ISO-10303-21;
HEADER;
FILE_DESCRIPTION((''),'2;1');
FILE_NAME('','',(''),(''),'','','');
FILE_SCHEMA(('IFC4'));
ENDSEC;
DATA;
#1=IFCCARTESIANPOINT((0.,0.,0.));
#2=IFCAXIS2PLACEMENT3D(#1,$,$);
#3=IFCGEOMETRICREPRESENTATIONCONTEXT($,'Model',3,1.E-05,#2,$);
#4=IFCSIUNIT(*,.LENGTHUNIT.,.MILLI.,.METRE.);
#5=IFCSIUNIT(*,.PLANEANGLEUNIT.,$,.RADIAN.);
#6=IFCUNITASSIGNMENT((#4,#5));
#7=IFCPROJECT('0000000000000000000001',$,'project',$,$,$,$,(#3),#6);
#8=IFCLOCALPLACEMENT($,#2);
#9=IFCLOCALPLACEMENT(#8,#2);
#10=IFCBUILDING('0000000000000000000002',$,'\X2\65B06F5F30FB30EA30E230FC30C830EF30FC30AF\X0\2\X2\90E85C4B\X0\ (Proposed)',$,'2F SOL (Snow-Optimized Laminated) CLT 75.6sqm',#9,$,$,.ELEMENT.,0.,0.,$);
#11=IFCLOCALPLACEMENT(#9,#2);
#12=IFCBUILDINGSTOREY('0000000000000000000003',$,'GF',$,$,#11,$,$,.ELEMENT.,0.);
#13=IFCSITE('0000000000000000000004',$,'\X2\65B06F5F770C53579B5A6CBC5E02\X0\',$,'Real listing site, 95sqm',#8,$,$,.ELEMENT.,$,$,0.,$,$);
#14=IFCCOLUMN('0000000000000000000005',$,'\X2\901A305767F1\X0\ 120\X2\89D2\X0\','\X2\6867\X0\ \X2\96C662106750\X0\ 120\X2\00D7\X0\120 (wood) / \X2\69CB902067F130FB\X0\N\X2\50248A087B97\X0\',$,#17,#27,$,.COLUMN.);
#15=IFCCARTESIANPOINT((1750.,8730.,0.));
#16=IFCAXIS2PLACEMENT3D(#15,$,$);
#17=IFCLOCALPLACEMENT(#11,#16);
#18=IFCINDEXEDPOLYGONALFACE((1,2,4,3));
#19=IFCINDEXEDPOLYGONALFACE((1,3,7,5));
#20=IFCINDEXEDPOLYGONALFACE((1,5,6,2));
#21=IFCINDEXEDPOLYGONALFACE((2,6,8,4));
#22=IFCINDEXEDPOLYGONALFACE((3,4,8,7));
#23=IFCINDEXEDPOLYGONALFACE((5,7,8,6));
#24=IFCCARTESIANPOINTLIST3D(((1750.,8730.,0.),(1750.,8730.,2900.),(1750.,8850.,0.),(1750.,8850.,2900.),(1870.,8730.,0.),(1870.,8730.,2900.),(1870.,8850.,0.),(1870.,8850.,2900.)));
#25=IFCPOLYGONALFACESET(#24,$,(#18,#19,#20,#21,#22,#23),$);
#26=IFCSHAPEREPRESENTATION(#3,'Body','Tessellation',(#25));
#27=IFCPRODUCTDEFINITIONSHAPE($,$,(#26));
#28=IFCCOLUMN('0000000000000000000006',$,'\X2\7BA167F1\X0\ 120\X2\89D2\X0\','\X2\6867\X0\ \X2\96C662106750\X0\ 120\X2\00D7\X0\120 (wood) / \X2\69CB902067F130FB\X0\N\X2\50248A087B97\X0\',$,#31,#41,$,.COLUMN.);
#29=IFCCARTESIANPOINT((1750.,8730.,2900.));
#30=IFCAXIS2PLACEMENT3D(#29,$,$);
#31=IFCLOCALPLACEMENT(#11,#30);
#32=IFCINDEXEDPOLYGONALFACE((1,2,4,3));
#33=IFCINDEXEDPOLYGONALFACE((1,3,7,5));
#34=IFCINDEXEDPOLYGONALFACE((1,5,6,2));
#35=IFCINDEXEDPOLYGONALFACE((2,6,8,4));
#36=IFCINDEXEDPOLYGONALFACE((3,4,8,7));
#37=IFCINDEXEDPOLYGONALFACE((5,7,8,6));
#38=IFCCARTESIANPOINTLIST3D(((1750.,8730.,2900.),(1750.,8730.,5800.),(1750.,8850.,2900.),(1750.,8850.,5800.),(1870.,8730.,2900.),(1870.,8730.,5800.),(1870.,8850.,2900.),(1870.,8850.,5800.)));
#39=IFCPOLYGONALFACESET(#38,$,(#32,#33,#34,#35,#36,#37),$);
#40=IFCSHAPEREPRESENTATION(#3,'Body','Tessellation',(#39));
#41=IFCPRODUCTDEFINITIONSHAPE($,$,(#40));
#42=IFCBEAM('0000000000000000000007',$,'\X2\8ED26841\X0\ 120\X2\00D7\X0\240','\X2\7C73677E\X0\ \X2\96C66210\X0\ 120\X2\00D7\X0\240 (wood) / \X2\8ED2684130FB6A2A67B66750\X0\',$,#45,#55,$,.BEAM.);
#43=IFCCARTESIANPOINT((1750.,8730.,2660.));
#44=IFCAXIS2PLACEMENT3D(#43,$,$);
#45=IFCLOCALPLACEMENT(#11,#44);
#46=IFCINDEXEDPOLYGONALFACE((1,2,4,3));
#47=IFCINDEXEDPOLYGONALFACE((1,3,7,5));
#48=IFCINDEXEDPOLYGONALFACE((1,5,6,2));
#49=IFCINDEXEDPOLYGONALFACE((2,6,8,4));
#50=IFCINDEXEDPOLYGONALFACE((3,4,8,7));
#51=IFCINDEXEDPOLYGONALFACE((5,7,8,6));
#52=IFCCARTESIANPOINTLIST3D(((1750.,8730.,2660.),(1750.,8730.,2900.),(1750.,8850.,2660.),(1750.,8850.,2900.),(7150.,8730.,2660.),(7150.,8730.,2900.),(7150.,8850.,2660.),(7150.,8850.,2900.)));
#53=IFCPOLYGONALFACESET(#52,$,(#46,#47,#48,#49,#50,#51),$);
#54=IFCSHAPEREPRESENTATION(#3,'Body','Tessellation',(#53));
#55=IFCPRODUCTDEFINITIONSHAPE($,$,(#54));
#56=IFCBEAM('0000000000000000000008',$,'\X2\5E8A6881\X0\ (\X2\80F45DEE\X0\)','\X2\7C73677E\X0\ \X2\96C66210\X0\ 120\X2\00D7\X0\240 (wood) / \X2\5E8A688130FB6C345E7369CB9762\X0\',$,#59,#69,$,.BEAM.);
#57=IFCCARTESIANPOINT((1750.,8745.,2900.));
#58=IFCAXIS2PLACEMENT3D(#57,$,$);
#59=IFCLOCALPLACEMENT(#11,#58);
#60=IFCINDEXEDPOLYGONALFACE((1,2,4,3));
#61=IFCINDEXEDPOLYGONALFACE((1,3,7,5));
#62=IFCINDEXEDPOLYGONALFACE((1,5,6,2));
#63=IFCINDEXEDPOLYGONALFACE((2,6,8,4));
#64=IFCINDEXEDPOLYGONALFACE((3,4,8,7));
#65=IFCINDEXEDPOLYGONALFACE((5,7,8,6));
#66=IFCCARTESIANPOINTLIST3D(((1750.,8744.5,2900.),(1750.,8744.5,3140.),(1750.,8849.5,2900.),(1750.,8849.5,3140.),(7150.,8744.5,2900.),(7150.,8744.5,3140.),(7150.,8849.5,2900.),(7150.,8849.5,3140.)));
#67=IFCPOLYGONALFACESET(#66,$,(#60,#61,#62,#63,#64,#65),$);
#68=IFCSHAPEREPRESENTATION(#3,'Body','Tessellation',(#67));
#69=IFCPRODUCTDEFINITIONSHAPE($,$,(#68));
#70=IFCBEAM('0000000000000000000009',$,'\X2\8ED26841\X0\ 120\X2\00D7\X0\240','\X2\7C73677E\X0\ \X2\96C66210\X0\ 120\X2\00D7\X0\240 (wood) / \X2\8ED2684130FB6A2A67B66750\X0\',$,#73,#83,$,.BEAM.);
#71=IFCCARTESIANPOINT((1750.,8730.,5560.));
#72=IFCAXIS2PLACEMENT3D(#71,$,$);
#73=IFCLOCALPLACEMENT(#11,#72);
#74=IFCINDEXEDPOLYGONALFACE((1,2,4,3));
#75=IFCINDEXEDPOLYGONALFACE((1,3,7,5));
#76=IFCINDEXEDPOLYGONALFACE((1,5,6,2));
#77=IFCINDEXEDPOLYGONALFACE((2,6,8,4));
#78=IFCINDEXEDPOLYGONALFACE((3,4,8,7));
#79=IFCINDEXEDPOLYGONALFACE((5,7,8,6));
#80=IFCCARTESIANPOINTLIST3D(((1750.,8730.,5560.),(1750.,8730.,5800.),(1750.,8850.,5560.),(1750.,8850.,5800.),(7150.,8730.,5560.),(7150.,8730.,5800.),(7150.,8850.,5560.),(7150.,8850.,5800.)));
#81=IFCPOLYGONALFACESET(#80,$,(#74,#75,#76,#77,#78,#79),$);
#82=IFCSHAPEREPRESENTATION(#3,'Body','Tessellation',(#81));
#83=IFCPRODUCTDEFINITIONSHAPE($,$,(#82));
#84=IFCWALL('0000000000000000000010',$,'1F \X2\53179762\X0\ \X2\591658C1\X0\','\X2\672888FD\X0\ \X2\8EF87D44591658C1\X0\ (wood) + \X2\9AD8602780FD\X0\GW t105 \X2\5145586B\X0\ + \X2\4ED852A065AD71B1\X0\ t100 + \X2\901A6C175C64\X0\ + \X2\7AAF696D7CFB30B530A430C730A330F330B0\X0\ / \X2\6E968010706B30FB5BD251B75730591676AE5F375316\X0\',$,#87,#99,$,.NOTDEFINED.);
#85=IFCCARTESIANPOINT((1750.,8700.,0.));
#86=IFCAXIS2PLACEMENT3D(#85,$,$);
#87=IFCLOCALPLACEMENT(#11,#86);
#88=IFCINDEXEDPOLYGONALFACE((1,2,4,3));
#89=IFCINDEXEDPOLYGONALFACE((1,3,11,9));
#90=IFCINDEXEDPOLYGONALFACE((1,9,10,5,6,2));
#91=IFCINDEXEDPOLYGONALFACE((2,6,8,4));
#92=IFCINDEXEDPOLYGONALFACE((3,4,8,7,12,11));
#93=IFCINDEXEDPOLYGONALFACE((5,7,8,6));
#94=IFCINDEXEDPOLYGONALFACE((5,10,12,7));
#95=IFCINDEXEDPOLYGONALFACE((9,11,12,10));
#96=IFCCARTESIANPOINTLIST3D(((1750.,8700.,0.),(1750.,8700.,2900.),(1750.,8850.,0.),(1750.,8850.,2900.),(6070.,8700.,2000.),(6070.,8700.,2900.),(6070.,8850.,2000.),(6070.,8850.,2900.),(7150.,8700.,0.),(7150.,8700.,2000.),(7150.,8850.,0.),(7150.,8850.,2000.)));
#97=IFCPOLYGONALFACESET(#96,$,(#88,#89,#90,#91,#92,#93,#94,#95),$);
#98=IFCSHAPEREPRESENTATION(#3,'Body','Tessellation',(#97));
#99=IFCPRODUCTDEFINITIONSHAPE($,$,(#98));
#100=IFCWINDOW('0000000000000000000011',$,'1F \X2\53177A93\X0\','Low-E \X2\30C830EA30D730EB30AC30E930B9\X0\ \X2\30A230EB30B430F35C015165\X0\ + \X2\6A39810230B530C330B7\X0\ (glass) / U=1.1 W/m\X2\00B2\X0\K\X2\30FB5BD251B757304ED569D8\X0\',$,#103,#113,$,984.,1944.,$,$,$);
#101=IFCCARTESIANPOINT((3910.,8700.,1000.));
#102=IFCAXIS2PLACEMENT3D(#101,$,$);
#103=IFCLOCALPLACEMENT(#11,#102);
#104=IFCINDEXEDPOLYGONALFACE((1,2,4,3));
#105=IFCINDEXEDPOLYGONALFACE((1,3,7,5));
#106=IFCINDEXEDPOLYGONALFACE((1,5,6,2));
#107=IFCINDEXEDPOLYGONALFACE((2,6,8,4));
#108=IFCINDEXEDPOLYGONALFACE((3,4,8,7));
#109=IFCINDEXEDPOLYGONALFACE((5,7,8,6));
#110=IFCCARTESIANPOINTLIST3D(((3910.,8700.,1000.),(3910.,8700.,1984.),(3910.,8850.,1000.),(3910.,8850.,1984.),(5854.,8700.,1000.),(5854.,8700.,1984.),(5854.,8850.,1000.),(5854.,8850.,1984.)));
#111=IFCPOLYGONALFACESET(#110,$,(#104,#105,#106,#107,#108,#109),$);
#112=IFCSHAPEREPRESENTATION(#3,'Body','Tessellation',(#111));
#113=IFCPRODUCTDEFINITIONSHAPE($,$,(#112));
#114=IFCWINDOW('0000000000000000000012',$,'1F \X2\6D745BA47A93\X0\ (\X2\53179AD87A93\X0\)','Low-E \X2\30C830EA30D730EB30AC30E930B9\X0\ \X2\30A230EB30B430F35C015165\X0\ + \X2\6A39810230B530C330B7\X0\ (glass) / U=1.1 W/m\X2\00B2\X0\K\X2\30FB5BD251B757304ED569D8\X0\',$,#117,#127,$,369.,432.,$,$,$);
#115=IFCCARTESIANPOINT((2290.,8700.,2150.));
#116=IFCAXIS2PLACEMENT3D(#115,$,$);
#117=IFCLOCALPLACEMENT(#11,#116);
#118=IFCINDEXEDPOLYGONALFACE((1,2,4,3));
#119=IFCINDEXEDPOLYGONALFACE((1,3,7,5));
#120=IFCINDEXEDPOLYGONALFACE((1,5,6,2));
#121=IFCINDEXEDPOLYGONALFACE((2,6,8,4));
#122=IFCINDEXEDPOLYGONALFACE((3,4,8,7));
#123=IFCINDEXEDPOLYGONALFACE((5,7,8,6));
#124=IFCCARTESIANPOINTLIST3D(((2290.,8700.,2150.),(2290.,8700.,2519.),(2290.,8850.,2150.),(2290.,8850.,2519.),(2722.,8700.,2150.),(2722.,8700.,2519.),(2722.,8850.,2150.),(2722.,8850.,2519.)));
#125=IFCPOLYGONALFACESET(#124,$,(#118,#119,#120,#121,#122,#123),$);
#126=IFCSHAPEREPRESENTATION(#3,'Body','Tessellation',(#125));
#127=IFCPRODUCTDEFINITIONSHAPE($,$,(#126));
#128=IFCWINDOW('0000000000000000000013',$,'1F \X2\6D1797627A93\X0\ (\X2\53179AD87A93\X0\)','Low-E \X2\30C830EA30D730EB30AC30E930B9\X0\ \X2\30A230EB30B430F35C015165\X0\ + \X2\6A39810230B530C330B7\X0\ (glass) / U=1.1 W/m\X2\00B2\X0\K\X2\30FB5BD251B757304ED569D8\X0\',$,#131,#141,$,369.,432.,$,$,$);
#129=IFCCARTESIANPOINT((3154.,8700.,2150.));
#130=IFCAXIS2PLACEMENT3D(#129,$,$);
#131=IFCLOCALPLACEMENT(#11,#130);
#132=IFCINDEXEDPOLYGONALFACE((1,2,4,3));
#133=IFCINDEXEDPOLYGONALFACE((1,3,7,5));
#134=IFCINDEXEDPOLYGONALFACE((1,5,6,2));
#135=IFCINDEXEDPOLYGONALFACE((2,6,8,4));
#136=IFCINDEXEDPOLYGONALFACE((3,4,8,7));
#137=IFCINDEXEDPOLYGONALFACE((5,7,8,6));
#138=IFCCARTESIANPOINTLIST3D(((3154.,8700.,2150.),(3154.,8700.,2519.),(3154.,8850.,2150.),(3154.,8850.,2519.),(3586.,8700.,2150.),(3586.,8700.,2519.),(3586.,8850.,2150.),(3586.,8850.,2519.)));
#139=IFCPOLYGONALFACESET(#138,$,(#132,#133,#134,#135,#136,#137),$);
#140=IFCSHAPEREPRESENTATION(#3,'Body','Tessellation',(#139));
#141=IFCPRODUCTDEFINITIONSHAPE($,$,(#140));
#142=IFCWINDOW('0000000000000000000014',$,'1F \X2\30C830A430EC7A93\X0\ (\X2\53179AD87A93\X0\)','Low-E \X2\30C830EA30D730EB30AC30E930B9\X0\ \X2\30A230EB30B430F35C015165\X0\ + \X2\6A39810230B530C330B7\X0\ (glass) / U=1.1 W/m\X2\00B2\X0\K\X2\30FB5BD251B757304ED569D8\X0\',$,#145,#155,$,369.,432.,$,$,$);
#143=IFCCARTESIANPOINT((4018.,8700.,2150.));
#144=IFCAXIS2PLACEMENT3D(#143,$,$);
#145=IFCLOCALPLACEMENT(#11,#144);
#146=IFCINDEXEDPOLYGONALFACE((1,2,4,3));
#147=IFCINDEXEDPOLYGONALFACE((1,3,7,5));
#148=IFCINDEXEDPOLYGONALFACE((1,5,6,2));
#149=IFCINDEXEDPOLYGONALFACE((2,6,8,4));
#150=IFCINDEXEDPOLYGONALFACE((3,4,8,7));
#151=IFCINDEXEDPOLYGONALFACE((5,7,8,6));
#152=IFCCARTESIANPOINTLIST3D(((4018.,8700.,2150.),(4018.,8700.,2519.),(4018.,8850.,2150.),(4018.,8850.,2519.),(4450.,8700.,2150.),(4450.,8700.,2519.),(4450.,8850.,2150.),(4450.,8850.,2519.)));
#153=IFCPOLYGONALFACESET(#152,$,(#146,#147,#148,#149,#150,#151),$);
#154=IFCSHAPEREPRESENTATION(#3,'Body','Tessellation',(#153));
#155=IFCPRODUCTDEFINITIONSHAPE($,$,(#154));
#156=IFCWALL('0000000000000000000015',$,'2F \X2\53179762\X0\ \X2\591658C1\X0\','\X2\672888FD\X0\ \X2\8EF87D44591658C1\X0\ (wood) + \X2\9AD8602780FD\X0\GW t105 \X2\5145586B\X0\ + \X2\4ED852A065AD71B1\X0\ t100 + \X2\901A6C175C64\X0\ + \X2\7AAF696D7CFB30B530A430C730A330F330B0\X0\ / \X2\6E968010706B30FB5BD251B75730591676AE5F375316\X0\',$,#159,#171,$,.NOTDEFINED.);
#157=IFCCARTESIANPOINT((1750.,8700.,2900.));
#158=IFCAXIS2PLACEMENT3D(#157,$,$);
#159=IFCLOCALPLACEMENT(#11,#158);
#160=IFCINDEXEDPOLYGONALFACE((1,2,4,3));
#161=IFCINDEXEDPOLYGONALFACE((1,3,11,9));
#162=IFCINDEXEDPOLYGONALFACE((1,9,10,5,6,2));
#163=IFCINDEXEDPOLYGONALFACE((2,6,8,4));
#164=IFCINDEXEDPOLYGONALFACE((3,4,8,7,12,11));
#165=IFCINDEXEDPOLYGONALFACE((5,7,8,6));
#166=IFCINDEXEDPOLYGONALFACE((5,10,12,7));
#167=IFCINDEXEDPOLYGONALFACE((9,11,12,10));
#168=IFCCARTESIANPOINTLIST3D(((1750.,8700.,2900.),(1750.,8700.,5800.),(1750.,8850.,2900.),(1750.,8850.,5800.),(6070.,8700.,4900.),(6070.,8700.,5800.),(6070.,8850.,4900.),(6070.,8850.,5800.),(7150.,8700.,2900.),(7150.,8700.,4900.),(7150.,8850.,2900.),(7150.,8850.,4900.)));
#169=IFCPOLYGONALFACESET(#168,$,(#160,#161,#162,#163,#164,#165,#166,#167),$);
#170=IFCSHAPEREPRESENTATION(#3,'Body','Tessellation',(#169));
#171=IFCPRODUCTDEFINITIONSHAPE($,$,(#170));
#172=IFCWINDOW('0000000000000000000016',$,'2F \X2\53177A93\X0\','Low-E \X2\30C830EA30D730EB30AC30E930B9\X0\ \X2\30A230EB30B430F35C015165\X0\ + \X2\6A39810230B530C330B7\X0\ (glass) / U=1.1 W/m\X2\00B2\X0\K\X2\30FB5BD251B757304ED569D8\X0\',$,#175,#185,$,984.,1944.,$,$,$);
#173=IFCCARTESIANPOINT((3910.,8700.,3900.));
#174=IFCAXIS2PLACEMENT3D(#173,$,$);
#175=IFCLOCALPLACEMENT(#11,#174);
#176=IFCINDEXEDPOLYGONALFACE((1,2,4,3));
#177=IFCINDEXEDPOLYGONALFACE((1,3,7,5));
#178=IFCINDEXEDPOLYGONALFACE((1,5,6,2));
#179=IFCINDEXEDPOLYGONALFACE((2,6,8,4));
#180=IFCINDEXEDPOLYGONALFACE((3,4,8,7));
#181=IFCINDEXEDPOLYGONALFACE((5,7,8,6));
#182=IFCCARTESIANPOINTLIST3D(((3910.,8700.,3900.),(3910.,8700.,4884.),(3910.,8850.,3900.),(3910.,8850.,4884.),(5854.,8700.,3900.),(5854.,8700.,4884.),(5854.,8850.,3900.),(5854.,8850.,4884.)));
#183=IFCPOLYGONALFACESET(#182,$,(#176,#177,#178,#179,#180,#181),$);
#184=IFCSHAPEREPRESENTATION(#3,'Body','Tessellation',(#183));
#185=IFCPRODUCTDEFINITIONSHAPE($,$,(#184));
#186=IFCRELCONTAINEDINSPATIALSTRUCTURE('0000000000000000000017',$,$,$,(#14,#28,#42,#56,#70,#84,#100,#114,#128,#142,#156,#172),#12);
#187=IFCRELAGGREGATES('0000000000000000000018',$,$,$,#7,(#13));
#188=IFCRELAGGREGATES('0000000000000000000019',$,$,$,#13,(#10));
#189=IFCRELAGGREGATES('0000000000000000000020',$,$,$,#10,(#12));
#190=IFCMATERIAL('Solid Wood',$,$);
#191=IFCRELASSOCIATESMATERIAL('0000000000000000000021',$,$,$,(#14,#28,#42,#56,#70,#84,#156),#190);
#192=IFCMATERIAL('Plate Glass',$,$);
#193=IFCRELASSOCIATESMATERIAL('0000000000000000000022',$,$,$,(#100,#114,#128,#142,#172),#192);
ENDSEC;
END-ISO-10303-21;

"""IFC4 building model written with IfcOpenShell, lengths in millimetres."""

from ifc_helpers import new_model, si_unit, frame, frame_2d, origin, place, context, project, spatial, rectangle, extrude, material, element, fill, save


model = new_model("IFC4")

# Units and contexts
model_context = context("Model", 3, precision=1e-05, world=origin())
ifc_project = project(units=[si_unit("LENGTHUNIT", "METRE", prefix="MILLI"), si_unit("PLANEANGLEUNIT", "RADIAN")], contexts=[model_context])

# Site, building, storey
site_placement = place(None, origin())
site = spatial("IfcSite", under=ifc_project, at=site_placement, Name="新潟県南魚沼市", ObjectType="Real listing site, 95sqm", CompositionType="ELEMENT", RefElevation=0.0)
building_placement = place(site_placement, origin())
building = spatial("IfcBuilding", under=site, at=building_placement, Name="新潟・リモートワーク2部屋 (Proposed)", ObjectType="2F SOL (Snow-Optimized Laminated) CLT 75.6sqm", CompositionType="ELEMENT", ElevationOfRefHeight=0.0, ElevationOfTerrain=0.0)
storey_placement = place(building_placement, origin())
storey = spatial("IfcBuildingStorey", under=building, at=storey_placement, Name="GF", CompositionType="ELEMENT", Elevation=0.0)

# Columns
ifc_material_1 = material(Name="Solid Wood")
column_1_placement = place(storey_placement, frame((1750.0, 8730.0, 0.0)))
element("IfcColumn", 1, at=column_1_placement, inside=storey, material=ifc_material_1, Name="通し柱 120角", Description="桧 集成材 120×120 (wood) / 構造柱・N値計算", PredefinedType="COLUMN", context=model_context, shape_type="SweptSolid", body=[
    extrude(rectangle(XDim=120.0, YDim=120.0, at=frame_2d((60.0, 60.0))), frame((1750.0, 8730.0, 0.0)), (0.0, 0.0, 1.0), 2900.0),
])
column_2_placement = place(storey_placement, frame((1750.0, 8730.0, 2900.0)))
element("IfcColumn", 2, at=column_2_placement, inside=storey, material=ifc_material_1, Name="管柱 120角", Description="桧 集成材 120×120 (wood) / 構造柱・N値計算", PredefinedType="COLUMN", context=model_context, shape_type="SweptSolid", body=[
    extrude(rectangle(XDim=120.0, YDim=120.0, at=frame_2d((60.0, 60.0))), frame((1750.0, 8730.0, 2900.0)), (0.0, 0.0, 1.0), 2900.0),
])

# Beams
beam_1_placement = place(storey_placement, frame((1750.0, 8730.0, 2660.0)))
element("IfcBeam", 3, at=beam_1_placement, inside=storey, material=ifc_material_1, Name="軒桁 120×240", Description="米松 集成 120×240 (wood) / 軒桁・横架材", PredefinedType="BEAM", context=model_context, shape_type="SweptSolid", body=[
    extrude(rectangle(XDim=5400.0, YDim=120.0, at=frame_2d((2700.0, 60.0))), frame((1750.0, 8730.0, 2660.0)), (0.0, 0.0, 1.0), 240.0),
])
beam_2_placement = place(storey_placement, frame((1750.0, 8745.0, 2900.0)))
element("IfcBeam", 4, at=beam_2_placement, inside=storey, material=ifc_material_1, Name="床梁 (胴差)", Description="米松 集成 120×240 (wood) / 床梁・水平構面", PredefinedType="BEAM", context=model_context, shape_type="SweptSolid", body=[
    extrude(rectangle(XDim=5400.0, YDim=105.0, at=frame_2d((2700.0, 52.0))), frame((1750.0, 8745.0, 2900.0)), (0.0, 0.0, 1.0), 240.0),
])
beam_3_placement = place(storey_placement, frame((1750.0, 8730.0, 5560.0)))
element("IfcBeam", 5, at=beam_3_placement, inside=storey, material=ifc_material_1, Name="軒桁 120×240", Description="米松 集成 120×240 (wood) / 軒桁・横架材", PredefinedType="BEAM", context=model_context, shape_type="SweptSolid", body=[
    extrude(rectangle(XDim=5400.0, YDim=120.0, at=frame_2d((2700.0, 60.0))), frame((1750.0, 8730.0, 5560.0)), (0.0, 0.0, 1.0), 240.0),
])

# Wall, openings, windows
wall_1_placement = place(storey_placement, frame((1750.0, 8700.0, 0.0)))
wall_1 = element("IfcWall", 6, at=wall_1_placement, inside=storey, material=ifc_material_1, Name="1F 北面 外壁", Description="木製 軸組外壁 (wood) + 高性能GW t105 充填 + 付加断熱 t100 + 通気層 + 窯業系サイディング / 準耐火・寒冷地外皮強化", PredefinedType="NOTDEFINED", context=model_context, shape_type="SweptSolid", body=[
    extrude(rectangle(XDim=5400.0, YDim=150.0, at=frame_2d((2700.0, 75.0))), frame((1750.0, 8700.0, 0.0)), (0.0, 0.0, 1.0), 2900.0),
])
opening_1_placement = place(storey_placement, frame((3910.0, 8700.0, 1000.0)))
opening_1 = element("IfcOpeningElement", 7, at=opening_1_placement, cuts=wall_1, PredefinedType="NOTDEFINED", context=model_context, shape_type="SweptSolid", body=[
    extrude(rectangle(XDim=1944.0, YDim=150.0, at=frame_2d((972.0, 75.0))), frame((3910.0, 8700.0, 1000.0)), (0.0, 0.0, 1.0), 984.0),
])
opening_2_placement = place(storey_placement, frame((2290.0, 8700.0, 2150.0)))
opening_2 = element("IfcOpeningElement", 8, at=opening_2_placement, cuts=wall_1, PredefinedType="NOTDEFINED", context=model_context, shape_type="SweptSolid", body=[
    extrude(rectangle(XDim=432.0, YDim=150.0, at=frame_2d((216.0, 75.0))), frame((2290.0, 8700.0, 2150.0)), (0.0, 0.0, 1.0), 369.0),
])
opening_3_placement = place(storey_placement, frame((3154.0, 8700.0, 2150.0)))
opening_3 = element("IfcOpeningElement", 9, at=opening_3_placement, cuts=wall_1, PredefinedType="NOTDEFINED", context=model_context, shape_type="SweptSolid", body=[
    extrude(rectangle(XDim=432.0, YDim=150.0, at=frame_2d((216.0, 75.0))), frame((3154.0, 8700.0, 2150.0)), (0.0, 0.0, 1.0), 369.0),
])
opening_4_placement = place(storey_placement, frame((4018.0, 8700.0, 2150.0)))
opening_4 = element("IfcOpeningElement", 10, at=opening_4_placement, cuts=wall_1, PredefinedType="NOTDEFINED", context=model_context, shape_type="SweptSolid", body=[
    extrude(rectangle(XDim=432.0, YDim=150.0, at=frame_2d((216.0, 75.0))), frame((4018.0, 8700.0, 2150.0)), (0.0, 0.0, 1.0), 369.0),
])
ifc_material_2 = material(Name="Plate Glass")
window_1_placement = place(storey_placement, frame((3910.0, 8700.0, 1000.0)))
window_1 = element("IfcWindow", 11, at=window_1_placement, inside=storey, material=ifc_material_2, Name="1F 北窓", Description="Low-E トリプルガラス アルゴン封入 + 樹脂サッシ (glass) / U=1.1 W/m²K・寒冷地仕様", OverallHeight=984.0, OverallWidth=1944.0, context=model_context, shape_type="SweptSolid", body=[
    extrude(rectangle(XDim=1944.0, YDim=150.0, at=frame_2d((972.0, 75.0))), frame((3910.0, 8700.0, 1000.0)), (0.0, 0.0, 1.0), 984.0),
])
fill(opening_1, window_1)
window_2_placement = place(storey_placement, frame((2290.0, 8700.0, 2150.0)))
window_2 = element("IfcWindow", 12, at=window_2_placement, inside=storey, material=ifc_material_2, Name="1F 浴室窓 (北高窓)", Description="Low-E トリプルガラス アルゴン封入 + 樹脂サッシ (glass) / U=1.1 W/m²K・寒冷地仕様", OverallHeight=369.0, OverallWidth=432.0, context=model_context, shape_type="SweptSolid", body=[
    extrude(rectangle(XDim=432.0, YDim=150.0, at=frame_2d((216.0, 75.0))), frame((2290.0, 8700.0, 2150.0)), (0.0, 0.0, 1.0), 369.0),
])
fill(opening_2, window_2)
window_3_placement = place(storey_placement, frame((3154.0, 8700.0, 2150.0)))
window_3 = element("IfcWindow", 13, at=window_3_placement, inside=storey, material=ifc_material_2, Name="1F 洗面窓 (北高窓)", Description="Low-E トリプルガラス アルゴン封入 + 樹脂サッシ (glass) / U=1.1 W/m²K・寒冷地仕様", OverallHeight=369.0, OverallWidth=432.0, context=model_context, shape_type="SweptSolid", body=[
    extrude(rectangle(XDim=432.0, YDim=150.0, at=frame_2d((216.0, 75.0))), frame((3154.0, 8700.0, 2150.0)), (0.0, 0.0, 1.0), 369.0),
])
fill(opening_3, window_3)
window_4_placement = place(storey_placement, frame((4018.0, 8700.0, 2150.0)))
window_4 = element("IfcWindow", 14, at=window_4_placement, inside=storey, material=ifc_material_2, Name="1F トイレ窓 (北高窓)", Description="Low-E トリプルガラス アルゴン封入 + 樹脂サッシ (glass) / U=1.1 W/m²K・寒冷地仕様", OverallHeight=369.0, OverallWidth=432.0, context=model_context, shape_type="SweptSolid", body=[
    extrude(rectangle(XDim=432.0, YDim=150.0, at=frame_2d((216.0, 75.0))), frame((4018.0, 8700.0, 2150.0)), (0.0, 0.0, 1.0), 369.0),
])
fill(opening_4, window_4)

# Wall, opening, window
wall_2_placement = place(storey_placement, frame((1750.0, 8700.0, 2900.0)))
wall_2 = element("IfcWall", 15, at=wall_2_placement, inside=storey, material=ifc_material_1, Name="2F 北面 外壁", Description="木製 軸組外壁 (wood) + 高性能GW t105 充填 + 付加断熱 t100 + 通気層 + 窯業系サイディング / 準耐火・寒冷地外皮強化", PredefinedType="NOTDEFINED", context=model_context, shape_type="SweptSolid", body=[
    extrude(rectangle(XDim=5400.0, YDim=150.0, at=frame_2d((2700.0, 75.0))), frame((1750.0, 8700.0, 2900.0)), (0.0, 0.0, 1.0), 2900.0),
])
opening_5_placement = place(storey_placement, frame((3910.0, 8700.0, 3900.0)))
opening_5 = element("IfcOpeningElement", 16, at=opening_5_placement, cuts=wall_2, PredefinedType="NOTDEFINED", context=model_context, shape_type="SweptSolid", body=[
    extrude(rectangle(XDim=1944.0, YDim=150.0, at=frame_2d((972.0, 75.0))), frame((3910.0, 8700.0, 3900.0)), (0.0, 0.0, 1.0), 984.0),
])
window_5_placement = place(storey_placement, frame((3910.0, 8700.0, 3900.0)))
window_5 = element("IfcWindow", 17, at=window_5_placement, inside=storey, material=ifc_material_2, Name="2F 北窓", Description="Low-E トリプルガラス アルゴン封入 + 樹脂サッシ (glass) / U=1.1 W/m²K・寒冷地仕様", OverallHeight=984.0, OverallWidth=1944.0, context=model_context, shape_type="SweptSolid", body=[
    extrude(rectangle(XDim=1944.0, YDim=150.0, at=frame_2d((972.0, 75.0))), frame((3910.0, 8700.0, 3900.0)), (0.0, 0.0, 1.0), 984.0),
])
fill(opening_5, window_5)

save(model, "model.ifc")
